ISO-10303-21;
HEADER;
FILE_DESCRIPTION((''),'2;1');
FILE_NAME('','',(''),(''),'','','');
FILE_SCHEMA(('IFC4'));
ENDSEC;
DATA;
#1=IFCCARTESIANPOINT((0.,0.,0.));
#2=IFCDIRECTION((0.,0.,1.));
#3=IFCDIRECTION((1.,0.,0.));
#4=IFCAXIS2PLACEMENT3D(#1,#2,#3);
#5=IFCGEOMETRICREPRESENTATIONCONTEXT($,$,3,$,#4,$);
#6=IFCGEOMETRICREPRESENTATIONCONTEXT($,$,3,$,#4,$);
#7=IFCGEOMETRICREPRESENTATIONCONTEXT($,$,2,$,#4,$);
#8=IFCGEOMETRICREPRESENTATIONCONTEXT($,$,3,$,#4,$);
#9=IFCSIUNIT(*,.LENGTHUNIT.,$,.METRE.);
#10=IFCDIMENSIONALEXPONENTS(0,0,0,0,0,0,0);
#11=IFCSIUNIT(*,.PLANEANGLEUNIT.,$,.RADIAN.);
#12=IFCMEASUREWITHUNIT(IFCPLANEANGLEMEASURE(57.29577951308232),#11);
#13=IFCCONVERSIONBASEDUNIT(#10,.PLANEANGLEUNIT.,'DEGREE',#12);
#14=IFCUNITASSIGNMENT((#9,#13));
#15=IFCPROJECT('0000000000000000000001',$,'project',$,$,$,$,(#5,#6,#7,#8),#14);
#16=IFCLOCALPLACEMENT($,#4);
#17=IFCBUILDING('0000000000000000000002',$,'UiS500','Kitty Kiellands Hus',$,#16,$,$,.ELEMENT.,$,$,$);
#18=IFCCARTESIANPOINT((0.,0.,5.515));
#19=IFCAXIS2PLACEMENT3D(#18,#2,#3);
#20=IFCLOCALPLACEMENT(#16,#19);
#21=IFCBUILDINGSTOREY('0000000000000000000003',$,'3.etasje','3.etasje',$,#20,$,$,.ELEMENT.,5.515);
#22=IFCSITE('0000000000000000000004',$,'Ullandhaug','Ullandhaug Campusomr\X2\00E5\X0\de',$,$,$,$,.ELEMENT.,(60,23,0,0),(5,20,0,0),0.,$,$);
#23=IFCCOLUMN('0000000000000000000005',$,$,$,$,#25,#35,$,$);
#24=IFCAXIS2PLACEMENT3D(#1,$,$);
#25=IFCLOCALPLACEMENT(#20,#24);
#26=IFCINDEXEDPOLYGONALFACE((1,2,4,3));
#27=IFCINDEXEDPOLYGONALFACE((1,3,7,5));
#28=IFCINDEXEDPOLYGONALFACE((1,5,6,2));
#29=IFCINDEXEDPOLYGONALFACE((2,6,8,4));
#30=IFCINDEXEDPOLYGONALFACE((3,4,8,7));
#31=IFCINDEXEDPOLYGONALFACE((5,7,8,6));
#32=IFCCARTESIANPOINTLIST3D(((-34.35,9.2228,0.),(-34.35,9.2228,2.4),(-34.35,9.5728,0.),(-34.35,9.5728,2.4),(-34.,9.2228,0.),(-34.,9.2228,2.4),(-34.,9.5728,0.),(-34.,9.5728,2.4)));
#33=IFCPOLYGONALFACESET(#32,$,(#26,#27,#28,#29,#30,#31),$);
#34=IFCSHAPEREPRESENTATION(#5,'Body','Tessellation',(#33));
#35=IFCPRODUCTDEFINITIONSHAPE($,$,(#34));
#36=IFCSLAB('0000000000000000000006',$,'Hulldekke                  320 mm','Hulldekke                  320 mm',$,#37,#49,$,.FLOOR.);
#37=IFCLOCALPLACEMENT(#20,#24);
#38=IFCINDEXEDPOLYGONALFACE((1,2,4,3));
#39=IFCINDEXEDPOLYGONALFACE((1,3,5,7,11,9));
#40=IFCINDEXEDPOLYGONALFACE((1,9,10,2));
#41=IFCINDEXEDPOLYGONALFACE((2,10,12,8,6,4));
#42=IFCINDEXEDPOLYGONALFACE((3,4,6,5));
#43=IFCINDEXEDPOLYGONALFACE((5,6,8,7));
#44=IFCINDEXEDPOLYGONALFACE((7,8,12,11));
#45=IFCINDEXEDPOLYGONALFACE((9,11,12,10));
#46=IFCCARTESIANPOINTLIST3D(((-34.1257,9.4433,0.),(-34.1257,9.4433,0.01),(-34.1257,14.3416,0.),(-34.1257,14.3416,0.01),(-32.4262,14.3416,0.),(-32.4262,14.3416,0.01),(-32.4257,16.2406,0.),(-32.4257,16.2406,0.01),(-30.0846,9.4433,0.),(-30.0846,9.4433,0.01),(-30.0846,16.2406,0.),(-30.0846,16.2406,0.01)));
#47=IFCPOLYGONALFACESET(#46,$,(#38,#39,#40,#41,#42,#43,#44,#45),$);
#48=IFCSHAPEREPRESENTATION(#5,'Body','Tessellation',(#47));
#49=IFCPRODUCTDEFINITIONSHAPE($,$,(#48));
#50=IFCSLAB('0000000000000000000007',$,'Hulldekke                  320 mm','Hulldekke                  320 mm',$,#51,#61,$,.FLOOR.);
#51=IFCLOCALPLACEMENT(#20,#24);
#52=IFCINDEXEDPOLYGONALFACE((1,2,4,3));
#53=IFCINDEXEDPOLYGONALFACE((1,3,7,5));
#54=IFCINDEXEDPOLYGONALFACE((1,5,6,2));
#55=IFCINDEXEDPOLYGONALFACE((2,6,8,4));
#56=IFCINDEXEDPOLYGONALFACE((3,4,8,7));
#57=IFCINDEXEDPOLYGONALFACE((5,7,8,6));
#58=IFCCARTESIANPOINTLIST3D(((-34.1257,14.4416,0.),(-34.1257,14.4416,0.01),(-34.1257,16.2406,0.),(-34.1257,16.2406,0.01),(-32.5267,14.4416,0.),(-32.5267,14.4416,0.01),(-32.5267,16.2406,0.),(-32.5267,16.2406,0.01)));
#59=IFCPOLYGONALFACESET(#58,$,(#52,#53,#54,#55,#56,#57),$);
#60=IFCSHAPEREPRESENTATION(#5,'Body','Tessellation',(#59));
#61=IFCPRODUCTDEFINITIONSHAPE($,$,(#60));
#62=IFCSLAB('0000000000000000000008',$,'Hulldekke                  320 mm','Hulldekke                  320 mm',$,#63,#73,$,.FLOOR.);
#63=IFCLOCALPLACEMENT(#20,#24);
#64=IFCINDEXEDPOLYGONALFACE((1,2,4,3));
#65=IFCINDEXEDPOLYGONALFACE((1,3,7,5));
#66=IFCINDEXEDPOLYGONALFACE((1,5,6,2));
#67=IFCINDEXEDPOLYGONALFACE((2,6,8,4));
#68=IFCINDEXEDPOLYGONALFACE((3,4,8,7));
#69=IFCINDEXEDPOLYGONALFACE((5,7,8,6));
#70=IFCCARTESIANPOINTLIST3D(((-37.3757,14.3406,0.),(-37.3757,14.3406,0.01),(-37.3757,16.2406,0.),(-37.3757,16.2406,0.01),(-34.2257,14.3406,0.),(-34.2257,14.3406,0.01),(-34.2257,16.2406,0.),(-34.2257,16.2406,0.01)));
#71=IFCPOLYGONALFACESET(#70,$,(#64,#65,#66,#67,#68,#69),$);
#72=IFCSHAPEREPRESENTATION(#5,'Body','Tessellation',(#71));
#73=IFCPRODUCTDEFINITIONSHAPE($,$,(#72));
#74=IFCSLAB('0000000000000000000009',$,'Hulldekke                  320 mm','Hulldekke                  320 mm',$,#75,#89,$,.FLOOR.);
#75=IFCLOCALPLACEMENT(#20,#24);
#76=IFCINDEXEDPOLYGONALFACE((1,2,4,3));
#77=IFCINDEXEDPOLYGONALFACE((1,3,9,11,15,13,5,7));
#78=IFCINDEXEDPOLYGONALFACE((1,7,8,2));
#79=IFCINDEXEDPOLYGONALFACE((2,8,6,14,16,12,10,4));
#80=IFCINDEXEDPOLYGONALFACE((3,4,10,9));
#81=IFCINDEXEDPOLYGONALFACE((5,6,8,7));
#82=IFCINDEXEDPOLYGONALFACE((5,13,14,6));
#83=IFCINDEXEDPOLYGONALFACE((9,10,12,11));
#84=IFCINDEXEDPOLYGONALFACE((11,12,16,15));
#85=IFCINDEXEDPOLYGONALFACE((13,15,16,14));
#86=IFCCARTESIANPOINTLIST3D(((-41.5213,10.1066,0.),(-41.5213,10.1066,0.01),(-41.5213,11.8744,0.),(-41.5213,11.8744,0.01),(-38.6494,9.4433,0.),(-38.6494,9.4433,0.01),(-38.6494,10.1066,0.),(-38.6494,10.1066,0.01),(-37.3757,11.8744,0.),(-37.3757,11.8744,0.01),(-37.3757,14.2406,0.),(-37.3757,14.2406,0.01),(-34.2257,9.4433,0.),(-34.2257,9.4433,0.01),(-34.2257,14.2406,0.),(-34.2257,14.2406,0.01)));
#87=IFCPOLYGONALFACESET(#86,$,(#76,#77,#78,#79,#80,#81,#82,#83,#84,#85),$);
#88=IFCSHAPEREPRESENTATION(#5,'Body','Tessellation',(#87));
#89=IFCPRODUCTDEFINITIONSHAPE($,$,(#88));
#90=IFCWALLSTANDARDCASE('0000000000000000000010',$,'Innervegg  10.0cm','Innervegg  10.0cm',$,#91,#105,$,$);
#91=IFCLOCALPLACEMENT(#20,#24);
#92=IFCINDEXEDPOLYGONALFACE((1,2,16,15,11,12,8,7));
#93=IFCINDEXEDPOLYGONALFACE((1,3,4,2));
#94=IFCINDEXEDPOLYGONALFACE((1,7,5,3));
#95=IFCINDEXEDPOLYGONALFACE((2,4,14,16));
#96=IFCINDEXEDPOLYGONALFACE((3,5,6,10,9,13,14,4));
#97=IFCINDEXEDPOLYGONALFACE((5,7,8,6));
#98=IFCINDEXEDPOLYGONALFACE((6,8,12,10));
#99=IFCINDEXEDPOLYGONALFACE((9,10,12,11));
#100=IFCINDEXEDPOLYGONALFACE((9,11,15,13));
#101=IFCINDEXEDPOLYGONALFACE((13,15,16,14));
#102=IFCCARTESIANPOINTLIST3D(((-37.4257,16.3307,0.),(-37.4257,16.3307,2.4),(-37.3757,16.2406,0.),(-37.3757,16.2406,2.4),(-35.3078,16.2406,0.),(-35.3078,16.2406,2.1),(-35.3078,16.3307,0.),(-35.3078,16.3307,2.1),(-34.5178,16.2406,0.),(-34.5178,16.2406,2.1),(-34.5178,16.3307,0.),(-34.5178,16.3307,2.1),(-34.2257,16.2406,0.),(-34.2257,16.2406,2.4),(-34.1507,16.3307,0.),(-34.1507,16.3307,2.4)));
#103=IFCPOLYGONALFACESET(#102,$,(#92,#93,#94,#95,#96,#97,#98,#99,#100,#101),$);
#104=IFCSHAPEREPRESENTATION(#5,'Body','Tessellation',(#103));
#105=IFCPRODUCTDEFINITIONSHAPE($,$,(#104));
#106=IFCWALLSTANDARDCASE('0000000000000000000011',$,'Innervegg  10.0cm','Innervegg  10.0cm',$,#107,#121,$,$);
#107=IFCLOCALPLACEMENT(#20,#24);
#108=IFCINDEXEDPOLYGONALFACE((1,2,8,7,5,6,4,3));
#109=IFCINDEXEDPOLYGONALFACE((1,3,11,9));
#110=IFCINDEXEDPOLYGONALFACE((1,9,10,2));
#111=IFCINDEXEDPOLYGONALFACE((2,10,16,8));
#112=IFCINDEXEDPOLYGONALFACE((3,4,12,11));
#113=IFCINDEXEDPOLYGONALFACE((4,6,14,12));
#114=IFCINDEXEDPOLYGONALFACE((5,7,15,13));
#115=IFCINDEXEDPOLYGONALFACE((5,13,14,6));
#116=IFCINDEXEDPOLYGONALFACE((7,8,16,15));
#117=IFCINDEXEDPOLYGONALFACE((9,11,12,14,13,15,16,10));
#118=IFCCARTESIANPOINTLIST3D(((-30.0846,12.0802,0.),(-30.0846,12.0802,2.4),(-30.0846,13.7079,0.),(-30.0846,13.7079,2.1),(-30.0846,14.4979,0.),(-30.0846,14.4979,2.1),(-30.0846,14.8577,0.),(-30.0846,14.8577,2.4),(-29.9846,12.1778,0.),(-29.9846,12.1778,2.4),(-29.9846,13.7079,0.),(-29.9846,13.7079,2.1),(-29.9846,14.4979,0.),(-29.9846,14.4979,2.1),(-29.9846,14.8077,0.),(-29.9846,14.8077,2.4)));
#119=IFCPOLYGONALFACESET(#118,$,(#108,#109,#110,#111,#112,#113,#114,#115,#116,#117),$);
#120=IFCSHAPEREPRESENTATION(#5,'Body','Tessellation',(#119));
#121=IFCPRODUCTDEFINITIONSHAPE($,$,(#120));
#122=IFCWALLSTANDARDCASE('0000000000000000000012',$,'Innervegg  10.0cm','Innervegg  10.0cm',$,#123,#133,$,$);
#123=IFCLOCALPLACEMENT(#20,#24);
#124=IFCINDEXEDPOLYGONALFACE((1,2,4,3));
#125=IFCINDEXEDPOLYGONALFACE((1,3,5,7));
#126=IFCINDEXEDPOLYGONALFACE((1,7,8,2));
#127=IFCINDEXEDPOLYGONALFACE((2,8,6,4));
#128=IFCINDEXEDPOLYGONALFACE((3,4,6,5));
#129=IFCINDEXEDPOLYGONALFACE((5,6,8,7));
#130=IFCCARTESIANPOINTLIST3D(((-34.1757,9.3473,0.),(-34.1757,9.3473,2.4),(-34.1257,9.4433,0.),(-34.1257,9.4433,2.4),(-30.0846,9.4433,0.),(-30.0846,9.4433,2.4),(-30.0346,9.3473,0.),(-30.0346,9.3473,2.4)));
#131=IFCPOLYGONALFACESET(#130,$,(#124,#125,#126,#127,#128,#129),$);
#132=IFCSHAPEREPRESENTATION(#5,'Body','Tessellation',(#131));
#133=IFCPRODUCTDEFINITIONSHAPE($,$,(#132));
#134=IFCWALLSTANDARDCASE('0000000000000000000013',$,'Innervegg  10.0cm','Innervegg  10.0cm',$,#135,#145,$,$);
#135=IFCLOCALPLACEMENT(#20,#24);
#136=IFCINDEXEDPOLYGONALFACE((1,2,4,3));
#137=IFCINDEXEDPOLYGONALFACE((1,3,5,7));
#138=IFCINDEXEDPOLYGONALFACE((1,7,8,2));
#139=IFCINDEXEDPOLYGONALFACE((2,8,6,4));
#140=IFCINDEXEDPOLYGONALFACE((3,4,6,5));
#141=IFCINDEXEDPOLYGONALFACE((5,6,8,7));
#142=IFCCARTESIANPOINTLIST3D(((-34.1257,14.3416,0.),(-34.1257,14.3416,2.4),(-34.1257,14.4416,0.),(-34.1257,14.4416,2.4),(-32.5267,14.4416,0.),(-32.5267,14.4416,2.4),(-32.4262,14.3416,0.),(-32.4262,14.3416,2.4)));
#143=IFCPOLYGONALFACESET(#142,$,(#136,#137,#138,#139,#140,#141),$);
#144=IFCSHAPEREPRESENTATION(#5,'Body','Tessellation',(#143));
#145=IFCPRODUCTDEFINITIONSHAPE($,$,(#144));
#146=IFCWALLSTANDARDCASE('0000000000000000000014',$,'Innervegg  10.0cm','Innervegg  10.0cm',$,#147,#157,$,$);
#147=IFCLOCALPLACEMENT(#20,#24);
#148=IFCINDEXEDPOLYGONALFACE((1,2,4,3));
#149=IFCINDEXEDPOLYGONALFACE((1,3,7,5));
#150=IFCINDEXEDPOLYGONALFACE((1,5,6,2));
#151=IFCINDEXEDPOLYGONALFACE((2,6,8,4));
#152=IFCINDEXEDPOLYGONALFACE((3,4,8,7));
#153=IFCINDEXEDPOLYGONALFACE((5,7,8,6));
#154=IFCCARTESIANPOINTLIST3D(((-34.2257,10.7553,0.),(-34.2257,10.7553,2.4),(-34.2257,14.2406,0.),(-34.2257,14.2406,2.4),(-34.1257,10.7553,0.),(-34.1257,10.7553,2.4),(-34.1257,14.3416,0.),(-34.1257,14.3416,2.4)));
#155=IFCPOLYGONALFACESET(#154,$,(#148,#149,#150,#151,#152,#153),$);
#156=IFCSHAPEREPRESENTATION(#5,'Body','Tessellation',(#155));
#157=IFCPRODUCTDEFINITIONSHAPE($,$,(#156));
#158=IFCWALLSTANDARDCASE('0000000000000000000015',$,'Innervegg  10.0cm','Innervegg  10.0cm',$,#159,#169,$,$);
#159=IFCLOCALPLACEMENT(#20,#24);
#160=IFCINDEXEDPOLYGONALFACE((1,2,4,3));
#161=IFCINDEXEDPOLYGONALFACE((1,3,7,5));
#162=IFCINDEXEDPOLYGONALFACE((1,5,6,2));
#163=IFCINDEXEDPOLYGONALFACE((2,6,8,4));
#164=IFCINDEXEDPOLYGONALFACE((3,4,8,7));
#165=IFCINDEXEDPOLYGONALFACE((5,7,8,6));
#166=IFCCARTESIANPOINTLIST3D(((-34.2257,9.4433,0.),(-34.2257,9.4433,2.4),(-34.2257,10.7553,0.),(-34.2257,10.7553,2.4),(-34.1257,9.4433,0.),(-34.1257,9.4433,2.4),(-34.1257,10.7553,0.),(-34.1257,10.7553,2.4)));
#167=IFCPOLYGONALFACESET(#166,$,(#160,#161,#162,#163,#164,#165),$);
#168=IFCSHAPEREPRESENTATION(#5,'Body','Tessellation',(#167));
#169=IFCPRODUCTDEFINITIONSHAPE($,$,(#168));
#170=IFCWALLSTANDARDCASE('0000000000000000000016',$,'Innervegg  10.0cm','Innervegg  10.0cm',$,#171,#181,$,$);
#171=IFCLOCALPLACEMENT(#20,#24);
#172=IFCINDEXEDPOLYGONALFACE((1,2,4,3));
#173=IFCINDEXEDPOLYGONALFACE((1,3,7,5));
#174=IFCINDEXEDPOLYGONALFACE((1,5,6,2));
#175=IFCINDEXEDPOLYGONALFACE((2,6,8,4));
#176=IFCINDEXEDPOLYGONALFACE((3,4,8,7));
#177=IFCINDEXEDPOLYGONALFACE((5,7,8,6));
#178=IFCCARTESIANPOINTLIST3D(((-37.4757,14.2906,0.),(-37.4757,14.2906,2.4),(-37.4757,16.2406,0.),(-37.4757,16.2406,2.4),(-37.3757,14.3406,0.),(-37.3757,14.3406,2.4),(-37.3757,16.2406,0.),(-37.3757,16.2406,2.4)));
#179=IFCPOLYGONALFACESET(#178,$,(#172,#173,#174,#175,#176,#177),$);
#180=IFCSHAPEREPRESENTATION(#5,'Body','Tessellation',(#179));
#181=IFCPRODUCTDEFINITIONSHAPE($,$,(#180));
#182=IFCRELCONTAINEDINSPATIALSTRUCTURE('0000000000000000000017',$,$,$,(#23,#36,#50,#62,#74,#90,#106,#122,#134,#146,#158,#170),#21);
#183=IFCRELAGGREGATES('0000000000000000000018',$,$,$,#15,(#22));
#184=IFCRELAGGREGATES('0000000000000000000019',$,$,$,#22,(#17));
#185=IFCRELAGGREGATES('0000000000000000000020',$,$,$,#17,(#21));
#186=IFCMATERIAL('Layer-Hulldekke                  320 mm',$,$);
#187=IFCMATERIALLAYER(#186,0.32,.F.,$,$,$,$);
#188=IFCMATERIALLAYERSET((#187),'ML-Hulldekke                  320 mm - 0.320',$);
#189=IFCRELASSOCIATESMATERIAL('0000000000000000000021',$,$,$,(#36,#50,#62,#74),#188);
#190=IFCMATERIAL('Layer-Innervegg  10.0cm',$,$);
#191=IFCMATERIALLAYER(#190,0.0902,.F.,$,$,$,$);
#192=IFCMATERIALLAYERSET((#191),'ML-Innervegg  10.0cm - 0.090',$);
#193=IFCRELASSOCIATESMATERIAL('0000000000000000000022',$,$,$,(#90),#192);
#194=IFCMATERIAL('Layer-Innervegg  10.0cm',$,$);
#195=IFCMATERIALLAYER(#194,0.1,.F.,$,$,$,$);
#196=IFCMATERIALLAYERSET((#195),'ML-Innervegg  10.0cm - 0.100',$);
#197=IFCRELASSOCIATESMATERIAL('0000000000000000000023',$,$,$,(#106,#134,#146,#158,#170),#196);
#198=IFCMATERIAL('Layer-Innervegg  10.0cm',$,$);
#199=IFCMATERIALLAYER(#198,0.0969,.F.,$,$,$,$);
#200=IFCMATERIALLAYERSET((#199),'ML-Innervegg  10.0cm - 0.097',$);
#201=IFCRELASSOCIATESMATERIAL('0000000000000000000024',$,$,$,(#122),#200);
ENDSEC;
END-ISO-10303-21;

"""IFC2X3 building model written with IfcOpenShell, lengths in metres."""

from ifc_helpers import new_model, entity, si_unit, converted_unit, frame, origin_with_axes, origin_2d_with_axis, place, context, project, spatial, polyline, rectangle, outline, extrude, material, layer, layer_set, layer_usage, element, save


model = new_model("IFC2X3")

# Units and contexts
context_of_model_1 = context(None, 3, world=origin_with_axes())
context_of_model_2 = context(None, 3, world=origin_with_axes())
context_of_model_3 = context(None, 2, world=origin_with_axes())
context_of_model_4 = context(None, 3, world=origin_with_axes())
ifc_project = project(units=[si_unit("LENGTHUNIT", "METRE"), converted_unit("PLANEANGLEUNIT", "DEGREE", entity("IfcPlaneAngleMeasure", 57.29577951308232), si_unit("PLANEANGLEUNIT", "RADIAN"), dimensions=[0, 0, 0, 0, 0, 0, 0])], contexts=[context_of_model_1, context_of_model_2, context_of_model_3, context_of_model_4])

# Site, building, storey
site = spatial("IfcSite", under=ifc_project, Name="Ullandhaug", Description="Ullandhaug Campusområde", CompositionType="ELEMENT", RefLatitude=(60, 23, 0, 0), RefLongitude=(5, 20, 0, 0), RefElevation=0.0)
building_placement = place(None, origin_with_axes())
building = spatial("IfcBuilding", under=site, at=building_placement, Name="UiS500", Description="Kitty Kiellands Hus", CompositionType="ELEMENT")
storey_placement = place(building_placement, frame((0.0, 0.0, 5.515), z_axis=(0.0, 0.0, 1.0), x_axis=(1.0, 0.0, 0.0)))
storey = spatial("IfcBuildingStorey", under=building, at=storey_placement, Name="3.etasje", Description="3.etasje", CompositionType="ELEMENT", Elevation=5.515)

# Column
column_placement = place(storey_placement, frame((-34.175, 9.3978, 0.0), z_axis=(0.0, 0.0, 1.0), x_axis=(1.0, 0.0, 0.0)))
element("IfcColumn", 1, at=column_placement, inside=storey, context=context_of_model_1, shape_type="SweptSolid", body=[
    extrude(rectangle(XDim=0.35, YDim=0.35, at=origin_2d_with_axis()), origin_with_axes(), (0.0, 0.0, 1.0), 2.4),
])

# Slabs
ifc_material_1 = material(Name="Layer-Hulldekke                  320 mm")
ifc_layer_1 = layer(ifc_material_1, 0.32, ventilated=False)
ifc_layer_set_1 = layer_set([ifc_layer_1], Name="ML-Hulldekke                  320 mm - 0.320")
ifc_layer_usage_1 = layer_usage(ifc_layer_set_1, "AXIS2", "POSITIVE", 0.0)
slab_1_placement = place(storey_placement, frame((-34.1257, 9.4433, 0.0), z_axis=(0.0, 0.0, 1.0), x_axis=(1.0, 0.0, 0.0)))
element("IfcSlab", 2, at=slab_1_placement, inside=storey, material=ifc_layer_usage_1, Name="Hulldekke                  320 mm", Description="Hulldekke                  320 mm", PredefinedType="FLOOR", context=context_of_model_1, shape_type="SweptSolid", body=[
    extrude(outline(polyline([(0.0, 0.0), (4.0411, 0.0), (4.0411, 6.7973), (1.7, 6.7973), (1.6995, 4.8983), (0.0, 4.8983), (0.0, 0.0)])), origin_with_axes(), (0.0, 0.0, 1.0), 0.01),
])
slab_2_placement = place(storey_placement, frame((-34.1257, 14.4416, 0.0), z_axis=(0.0, 0.0, 1.0), x_axis=(1.0, 0.0, 0.0)))
element("IfcSlab", 3, at=slab_2_placement, inside=storey, material=ifc_layer_usage_1, Name="Hulldekke                  320 mm", Description="Hulldekke                  320 mm", PredefinedType="FLOOR", context=context_of_model_1, shape_type="SweptSolid", body=[
    extrude(outline(polyline([(0.0, 0.0), (1.599, 0.0), (1.599, 1.799), (0.0, 1.799), (0.0, 0.0)])), origin_with_axes(), (0.0, 0.0, 1.0), 0.01),
])
slab_3_placement = place(storey_placement, frame((-37.3757, 16.2406, 0.0), z_axis=(0.0, 0.0, 1.0), x_axis=(1.0, 0.0, 0.0)))
element("IfcSlab", 4, at=slab_3_placement, inside=storey, material=ifc_layer_usage_1, Name="Hulldekke                  320 mm", Description="Hulldekke                  320 mm", PredefinedType="FLOOR", context=context_of_model_1, shape_type="SweptSolid", body=[
    extrude(outline(polyline([(0.0, 0.0), (1.9, 0.0), (1.9, 3.15), (0.0, 3.15), (0.0, 0.0)])), frame((0.0, 0.0, 0.0), z_axis=(0.0, 0.0, 1.0), x_axis=(0.0, -1.0, 0.0)), (0.0, 0.0, 1.0), 0.01),
])
slab_4_placement = place(storey_placement, frame((-38.6494, 9.4433, 0.0), z_axis=(0.0, 0.0, 1.0), x_axis=(1.0, 0.0, 0.0)))
element("IfcSlab", 5, at=slab_4_placement, inside=storey, material=ifc_layer_usage_1, Name="Hulldekke                  320 mm", Description="Hulldekke                  320 mm", PredefinedType="FLOOR", context=context_of_model_1, shape_type="SweptSolid", body=[
    extrude(outline(polyline([(0.0, 0.0), (4.4236, 0.0), (4.4236, 4.7973), (1.2736, 4.7973), (1.2736, 2.4311), (-2.8719, 2.4311), (-2.8719, 0.6633), (0.0, 0.6633), (0.0, 0.0)])), origin_with_axes(), (0.0, 0.0, 1.0), 0.01),
])

# Walls, openings
ifc_material_2 = material(Name="Layer-Innervegg  10.0cm")
ifc_layer_2 = layer(ifc_material_2, 0.0902, ventilated=False)
ifc_layer_set_2 = layer_set([ifc_layer_2], Name="ML-Innervegg  10.0cm - 0.090")
ifc_layer_usage_2 = layer_usage(ifc_layer_set_2, "AXIS2", "POSITIVE", 0.0)
wall_1_placement = place(storey_placement, frame((-37.3757, 16.2406, 0.0), z_axis=(0.0, 0.0, 1.0), x_axis=(1.0, 0.0, 0.0)))
wall_1 = element("IfcWallStandardCase", 6, at=wall_1_placement, inside=storey, material=ifc_layer_usage_2, Name="Innervegg  10.0cm", Description="Innervegg  10.0cm", context=context_of_model_1, shape_type="SweptSolid", body=[
    extrude(outline(polyline([(0.0, 0.0), (3.15, 0.0), (3.225, 0.0902), (-0.05, 0.0902), (0.0, 0.0)])), origin_with_axes(), (0.0, 0.0, 1.0), 2.4),
])
opening_1_placement = place(wall_1_placement, frame((2.0679, 0.0902, 0.0), z_axis=(0.0, 0.0, 1.0), x_axis=(1.0, 0.0, 0.0)))
element("IfcOpeningElement", 7, at=opening_1_placement, cuts=wall_1, context=context_of_model_1, shape_type="SweptSolid", body=[
    extrude(outline(polyline([(0.0, 0.0), (2.1, 0.0), (2.1, 0.79), (0.0, 0.79), (0.0, 0.0)])), frame((0.0, 0.0, 0.0), z_axis=(0.0, 1.0, 0.0), x_axis=(0.0, 0.0, 1.0)), (0.0, 0.0, -1.0), 0.0902),
])
ifc_material_3 = material(Name="Layer-Innervegg  10.0cm")
ifc_layer_3 = layer(ifc_material_3, 0.1, ventilated=False)
ifc_layer_set_3 = layer_set([ifc_layer_3], Name="ML-Innervegg  10.0cm - 0.100")
ifc_layer_usage_3 = layer_usage(ifc_layer_set_3, "AXIS2", "POSITIVE", 0.0)
wall_2_placement = place(storey_placement, frame((-30.0846, 14.8577, 0.0), z_axis=(0.0, 0.0, 1.0), x_axis=(0.0, -1.0, 0.0)))
wall_2 = element("IfcWallStandardCase", 8, at=wall_2_placement, inside=storey, material=ifc_layer_usage_3, Name="Innervegg  10.0cm", Description="Innervegg  10.0cm", context=context_of_model_1, shape_type="SweptSolid", body=[
    extrude(outline(polyline([(0.0, 0.0), (2.7775, 0.0), (2.6799, 0.1), (0.05, 0.1), (0.0, 0.0)])), frame((0.0, 0.0, 0.0), z_axis=(0.0, 0.0, 1.0), x_axis=(1.0, 0.0, 0.0)), (0.0, 0.0, 1.0), 2.4),
])
opening_2_placement = place(wall_2_placement, frame((0.3599, 0.1, 0.0), z_axis=(0.0, 0.0, 1.0), x_axis=(1.0, 0.0, 0.0)))
element("IfcOpeningElement", 9, at=opening_2_placement, cuts=wall_2, context=context_of_model_1, shape_type="SweptSolid", body=[
    extrude(outline(polyline([(0.0, 0.0), (2.1, 0.0), (2.1, 0.79), (0.0, 0.79), (0.0, 0.0)])), frame((0.0, 0.0, 0.0), z_axis=(0.0, 1.0, 0.0), x_axis=(0.0, 0.0, 1.0)), (0.0, 0.0, -1.0), 0.1),
])

# Walls
ifc_material_4 = material(Name="Layer-Innervegg  10.0cm")
ifc_layer_4 = layer(ifc_material_4, 0.0969, ventilated=False)
ifc_layer_set_4 = layer_set([ifc_layer_4], Name="ML-Innervegg  10.0cm - 0.097")
ifc_layer_usage_4 = layer_usage(ifc_layer_set_4, "AXIS2", "POSITIVE", 0.0)
wall_3_placement = place(storey_placement, frame((-34.1757, 9.3473, 0.0), z_axis=(0.0, 0.0, 1.0), x_axis=(1.0, 0.0, 0.0)))
element("IfcWallStandardCase", 10, at=wall_3_placement, inside=storey, material=ifc_layer_usage_4, Name="Innervegg  10.0cm", Description="Innervegg  10.0cm", context=context_of_model_1, shape_type="SweptSolid", body=[
    extrude(outline(polyline([(0.0, 0.0), (4.1411, 0.0), (4.0911, 0.096), (0.05, 0.096), (0.0, 0.0)])), origin_with_axes(), (0.0, 0.0, 1.0), 2.4),
])
wall_4_placement = place(storey_placement, frame((-32.5267, 14.4416, 0.0), z_axis=(0.0, 0.0, 1.0), x_axis=(-1.0, 0.0, 0.0)))
element("IfcWallStandardCase", 11, at=wall_4_placement, inside=storey, material=ifc_layer_usage_3, Name="Innervegg  10.0cm", Description="Innervegg  10.0cm", context=context_of_model_1, shape_type="SweptSolid", body=[
    extrude(outline(polyline([(0.0, 0.0), (1.599, 0.0), (1.599, 0.1), (-0.1005, 0.1), (0.0, 0.0)])), frame((0.0, 0.0, 0.0), z_axis=(0.0, 0.0, 1.0), x_axis=(1.0, 0.0, 0.0)), (0.0, 0.0, 1.0), 2.4),
])
wall_5_placement = place(storey_placement, frame((-34.2257, 14.2406, 0.0), z_axis=(0.0, 0.0, 1.0), x_axis=(0.0, -1.0, 0.0)))
element("IfcWallStandardCase", 12, at=wall_5_placement, inside=storey, material=ifc_layer_usage_3, Name="Innervegg  10.0cm", Description="Innervegg  10.0cm", context=context_of_model_1, shape_type="SweptSolid", body=[
    extrude(outline(polyline([(0.0, 0.0), (3.4853, 0.0), (3.4853, 0.1), (-0.101, 0.1), (0.0, 0.0)])), frame((0.0, 0.0, 0.0), z_axis=(0.0, 0.0, 1.0), x_axis=(1.0, 0.0, 0.0)), (0.0, 0.0, 1.0), 2.4),
])
wall_6_placement = place(storey_placement, frame((-34.2257, 10.7553, 0.0), z_axis=(0.0, 0.0, 1.0), x_axis=(0.0, -1.0, 0.0)))
element("IfcWallStandardCase", 13, at=wall_6_placement, inside=storey, material=ifc_layer_usage_3, Name="Innervegg  10.0cm", Description="Innervegg  10.0cm", context=context_of_model_1, shape_type="SweptSolid", body=[
    extrude(outline(polyline([(0.0, 0.0), (1.312, 0.0), (1.312, 0.1), (0.0, 0.1), (0.0, 0.0)])), frame((0.0, 0.0, 0.0), z_axis=(0.0, 0.0, 1.0), x_axis=(1.0, 0.0, 0.0)), (0.0, 0.0, 1.0), 2.4),
])
wall_7_placement = place(storey_placement, frame((-37.4757, 16.2406, 0.0), z_axis=(0.0, 0.0, 1.0), x_axis=(0.0, -1.0, 0.0)))
element("IfcWallStandardCase", 14, at=wall_7_placement, inside=storey, material=ifc_layer_usage_3, Name="Innervegg  10.0cm", Description="Innervegg  10.0cm", context=context_of_model_1, shape_type="SweptSolid", body=[
    extrude(outline(polyline([(0.0, 0.0), (1.95, 0.0), (1.9, 0.1), (0.0, 0.1), (0.0, 0.0)])), frame((0.0, 0.0, 0.0), z_axis=(0.0, 0.0, 1.0), x_axis=(1.0, 0.0, 0.0)), (0.0, 0.0, 1.0), 2.4),
])

save(model, "model.ifc")
